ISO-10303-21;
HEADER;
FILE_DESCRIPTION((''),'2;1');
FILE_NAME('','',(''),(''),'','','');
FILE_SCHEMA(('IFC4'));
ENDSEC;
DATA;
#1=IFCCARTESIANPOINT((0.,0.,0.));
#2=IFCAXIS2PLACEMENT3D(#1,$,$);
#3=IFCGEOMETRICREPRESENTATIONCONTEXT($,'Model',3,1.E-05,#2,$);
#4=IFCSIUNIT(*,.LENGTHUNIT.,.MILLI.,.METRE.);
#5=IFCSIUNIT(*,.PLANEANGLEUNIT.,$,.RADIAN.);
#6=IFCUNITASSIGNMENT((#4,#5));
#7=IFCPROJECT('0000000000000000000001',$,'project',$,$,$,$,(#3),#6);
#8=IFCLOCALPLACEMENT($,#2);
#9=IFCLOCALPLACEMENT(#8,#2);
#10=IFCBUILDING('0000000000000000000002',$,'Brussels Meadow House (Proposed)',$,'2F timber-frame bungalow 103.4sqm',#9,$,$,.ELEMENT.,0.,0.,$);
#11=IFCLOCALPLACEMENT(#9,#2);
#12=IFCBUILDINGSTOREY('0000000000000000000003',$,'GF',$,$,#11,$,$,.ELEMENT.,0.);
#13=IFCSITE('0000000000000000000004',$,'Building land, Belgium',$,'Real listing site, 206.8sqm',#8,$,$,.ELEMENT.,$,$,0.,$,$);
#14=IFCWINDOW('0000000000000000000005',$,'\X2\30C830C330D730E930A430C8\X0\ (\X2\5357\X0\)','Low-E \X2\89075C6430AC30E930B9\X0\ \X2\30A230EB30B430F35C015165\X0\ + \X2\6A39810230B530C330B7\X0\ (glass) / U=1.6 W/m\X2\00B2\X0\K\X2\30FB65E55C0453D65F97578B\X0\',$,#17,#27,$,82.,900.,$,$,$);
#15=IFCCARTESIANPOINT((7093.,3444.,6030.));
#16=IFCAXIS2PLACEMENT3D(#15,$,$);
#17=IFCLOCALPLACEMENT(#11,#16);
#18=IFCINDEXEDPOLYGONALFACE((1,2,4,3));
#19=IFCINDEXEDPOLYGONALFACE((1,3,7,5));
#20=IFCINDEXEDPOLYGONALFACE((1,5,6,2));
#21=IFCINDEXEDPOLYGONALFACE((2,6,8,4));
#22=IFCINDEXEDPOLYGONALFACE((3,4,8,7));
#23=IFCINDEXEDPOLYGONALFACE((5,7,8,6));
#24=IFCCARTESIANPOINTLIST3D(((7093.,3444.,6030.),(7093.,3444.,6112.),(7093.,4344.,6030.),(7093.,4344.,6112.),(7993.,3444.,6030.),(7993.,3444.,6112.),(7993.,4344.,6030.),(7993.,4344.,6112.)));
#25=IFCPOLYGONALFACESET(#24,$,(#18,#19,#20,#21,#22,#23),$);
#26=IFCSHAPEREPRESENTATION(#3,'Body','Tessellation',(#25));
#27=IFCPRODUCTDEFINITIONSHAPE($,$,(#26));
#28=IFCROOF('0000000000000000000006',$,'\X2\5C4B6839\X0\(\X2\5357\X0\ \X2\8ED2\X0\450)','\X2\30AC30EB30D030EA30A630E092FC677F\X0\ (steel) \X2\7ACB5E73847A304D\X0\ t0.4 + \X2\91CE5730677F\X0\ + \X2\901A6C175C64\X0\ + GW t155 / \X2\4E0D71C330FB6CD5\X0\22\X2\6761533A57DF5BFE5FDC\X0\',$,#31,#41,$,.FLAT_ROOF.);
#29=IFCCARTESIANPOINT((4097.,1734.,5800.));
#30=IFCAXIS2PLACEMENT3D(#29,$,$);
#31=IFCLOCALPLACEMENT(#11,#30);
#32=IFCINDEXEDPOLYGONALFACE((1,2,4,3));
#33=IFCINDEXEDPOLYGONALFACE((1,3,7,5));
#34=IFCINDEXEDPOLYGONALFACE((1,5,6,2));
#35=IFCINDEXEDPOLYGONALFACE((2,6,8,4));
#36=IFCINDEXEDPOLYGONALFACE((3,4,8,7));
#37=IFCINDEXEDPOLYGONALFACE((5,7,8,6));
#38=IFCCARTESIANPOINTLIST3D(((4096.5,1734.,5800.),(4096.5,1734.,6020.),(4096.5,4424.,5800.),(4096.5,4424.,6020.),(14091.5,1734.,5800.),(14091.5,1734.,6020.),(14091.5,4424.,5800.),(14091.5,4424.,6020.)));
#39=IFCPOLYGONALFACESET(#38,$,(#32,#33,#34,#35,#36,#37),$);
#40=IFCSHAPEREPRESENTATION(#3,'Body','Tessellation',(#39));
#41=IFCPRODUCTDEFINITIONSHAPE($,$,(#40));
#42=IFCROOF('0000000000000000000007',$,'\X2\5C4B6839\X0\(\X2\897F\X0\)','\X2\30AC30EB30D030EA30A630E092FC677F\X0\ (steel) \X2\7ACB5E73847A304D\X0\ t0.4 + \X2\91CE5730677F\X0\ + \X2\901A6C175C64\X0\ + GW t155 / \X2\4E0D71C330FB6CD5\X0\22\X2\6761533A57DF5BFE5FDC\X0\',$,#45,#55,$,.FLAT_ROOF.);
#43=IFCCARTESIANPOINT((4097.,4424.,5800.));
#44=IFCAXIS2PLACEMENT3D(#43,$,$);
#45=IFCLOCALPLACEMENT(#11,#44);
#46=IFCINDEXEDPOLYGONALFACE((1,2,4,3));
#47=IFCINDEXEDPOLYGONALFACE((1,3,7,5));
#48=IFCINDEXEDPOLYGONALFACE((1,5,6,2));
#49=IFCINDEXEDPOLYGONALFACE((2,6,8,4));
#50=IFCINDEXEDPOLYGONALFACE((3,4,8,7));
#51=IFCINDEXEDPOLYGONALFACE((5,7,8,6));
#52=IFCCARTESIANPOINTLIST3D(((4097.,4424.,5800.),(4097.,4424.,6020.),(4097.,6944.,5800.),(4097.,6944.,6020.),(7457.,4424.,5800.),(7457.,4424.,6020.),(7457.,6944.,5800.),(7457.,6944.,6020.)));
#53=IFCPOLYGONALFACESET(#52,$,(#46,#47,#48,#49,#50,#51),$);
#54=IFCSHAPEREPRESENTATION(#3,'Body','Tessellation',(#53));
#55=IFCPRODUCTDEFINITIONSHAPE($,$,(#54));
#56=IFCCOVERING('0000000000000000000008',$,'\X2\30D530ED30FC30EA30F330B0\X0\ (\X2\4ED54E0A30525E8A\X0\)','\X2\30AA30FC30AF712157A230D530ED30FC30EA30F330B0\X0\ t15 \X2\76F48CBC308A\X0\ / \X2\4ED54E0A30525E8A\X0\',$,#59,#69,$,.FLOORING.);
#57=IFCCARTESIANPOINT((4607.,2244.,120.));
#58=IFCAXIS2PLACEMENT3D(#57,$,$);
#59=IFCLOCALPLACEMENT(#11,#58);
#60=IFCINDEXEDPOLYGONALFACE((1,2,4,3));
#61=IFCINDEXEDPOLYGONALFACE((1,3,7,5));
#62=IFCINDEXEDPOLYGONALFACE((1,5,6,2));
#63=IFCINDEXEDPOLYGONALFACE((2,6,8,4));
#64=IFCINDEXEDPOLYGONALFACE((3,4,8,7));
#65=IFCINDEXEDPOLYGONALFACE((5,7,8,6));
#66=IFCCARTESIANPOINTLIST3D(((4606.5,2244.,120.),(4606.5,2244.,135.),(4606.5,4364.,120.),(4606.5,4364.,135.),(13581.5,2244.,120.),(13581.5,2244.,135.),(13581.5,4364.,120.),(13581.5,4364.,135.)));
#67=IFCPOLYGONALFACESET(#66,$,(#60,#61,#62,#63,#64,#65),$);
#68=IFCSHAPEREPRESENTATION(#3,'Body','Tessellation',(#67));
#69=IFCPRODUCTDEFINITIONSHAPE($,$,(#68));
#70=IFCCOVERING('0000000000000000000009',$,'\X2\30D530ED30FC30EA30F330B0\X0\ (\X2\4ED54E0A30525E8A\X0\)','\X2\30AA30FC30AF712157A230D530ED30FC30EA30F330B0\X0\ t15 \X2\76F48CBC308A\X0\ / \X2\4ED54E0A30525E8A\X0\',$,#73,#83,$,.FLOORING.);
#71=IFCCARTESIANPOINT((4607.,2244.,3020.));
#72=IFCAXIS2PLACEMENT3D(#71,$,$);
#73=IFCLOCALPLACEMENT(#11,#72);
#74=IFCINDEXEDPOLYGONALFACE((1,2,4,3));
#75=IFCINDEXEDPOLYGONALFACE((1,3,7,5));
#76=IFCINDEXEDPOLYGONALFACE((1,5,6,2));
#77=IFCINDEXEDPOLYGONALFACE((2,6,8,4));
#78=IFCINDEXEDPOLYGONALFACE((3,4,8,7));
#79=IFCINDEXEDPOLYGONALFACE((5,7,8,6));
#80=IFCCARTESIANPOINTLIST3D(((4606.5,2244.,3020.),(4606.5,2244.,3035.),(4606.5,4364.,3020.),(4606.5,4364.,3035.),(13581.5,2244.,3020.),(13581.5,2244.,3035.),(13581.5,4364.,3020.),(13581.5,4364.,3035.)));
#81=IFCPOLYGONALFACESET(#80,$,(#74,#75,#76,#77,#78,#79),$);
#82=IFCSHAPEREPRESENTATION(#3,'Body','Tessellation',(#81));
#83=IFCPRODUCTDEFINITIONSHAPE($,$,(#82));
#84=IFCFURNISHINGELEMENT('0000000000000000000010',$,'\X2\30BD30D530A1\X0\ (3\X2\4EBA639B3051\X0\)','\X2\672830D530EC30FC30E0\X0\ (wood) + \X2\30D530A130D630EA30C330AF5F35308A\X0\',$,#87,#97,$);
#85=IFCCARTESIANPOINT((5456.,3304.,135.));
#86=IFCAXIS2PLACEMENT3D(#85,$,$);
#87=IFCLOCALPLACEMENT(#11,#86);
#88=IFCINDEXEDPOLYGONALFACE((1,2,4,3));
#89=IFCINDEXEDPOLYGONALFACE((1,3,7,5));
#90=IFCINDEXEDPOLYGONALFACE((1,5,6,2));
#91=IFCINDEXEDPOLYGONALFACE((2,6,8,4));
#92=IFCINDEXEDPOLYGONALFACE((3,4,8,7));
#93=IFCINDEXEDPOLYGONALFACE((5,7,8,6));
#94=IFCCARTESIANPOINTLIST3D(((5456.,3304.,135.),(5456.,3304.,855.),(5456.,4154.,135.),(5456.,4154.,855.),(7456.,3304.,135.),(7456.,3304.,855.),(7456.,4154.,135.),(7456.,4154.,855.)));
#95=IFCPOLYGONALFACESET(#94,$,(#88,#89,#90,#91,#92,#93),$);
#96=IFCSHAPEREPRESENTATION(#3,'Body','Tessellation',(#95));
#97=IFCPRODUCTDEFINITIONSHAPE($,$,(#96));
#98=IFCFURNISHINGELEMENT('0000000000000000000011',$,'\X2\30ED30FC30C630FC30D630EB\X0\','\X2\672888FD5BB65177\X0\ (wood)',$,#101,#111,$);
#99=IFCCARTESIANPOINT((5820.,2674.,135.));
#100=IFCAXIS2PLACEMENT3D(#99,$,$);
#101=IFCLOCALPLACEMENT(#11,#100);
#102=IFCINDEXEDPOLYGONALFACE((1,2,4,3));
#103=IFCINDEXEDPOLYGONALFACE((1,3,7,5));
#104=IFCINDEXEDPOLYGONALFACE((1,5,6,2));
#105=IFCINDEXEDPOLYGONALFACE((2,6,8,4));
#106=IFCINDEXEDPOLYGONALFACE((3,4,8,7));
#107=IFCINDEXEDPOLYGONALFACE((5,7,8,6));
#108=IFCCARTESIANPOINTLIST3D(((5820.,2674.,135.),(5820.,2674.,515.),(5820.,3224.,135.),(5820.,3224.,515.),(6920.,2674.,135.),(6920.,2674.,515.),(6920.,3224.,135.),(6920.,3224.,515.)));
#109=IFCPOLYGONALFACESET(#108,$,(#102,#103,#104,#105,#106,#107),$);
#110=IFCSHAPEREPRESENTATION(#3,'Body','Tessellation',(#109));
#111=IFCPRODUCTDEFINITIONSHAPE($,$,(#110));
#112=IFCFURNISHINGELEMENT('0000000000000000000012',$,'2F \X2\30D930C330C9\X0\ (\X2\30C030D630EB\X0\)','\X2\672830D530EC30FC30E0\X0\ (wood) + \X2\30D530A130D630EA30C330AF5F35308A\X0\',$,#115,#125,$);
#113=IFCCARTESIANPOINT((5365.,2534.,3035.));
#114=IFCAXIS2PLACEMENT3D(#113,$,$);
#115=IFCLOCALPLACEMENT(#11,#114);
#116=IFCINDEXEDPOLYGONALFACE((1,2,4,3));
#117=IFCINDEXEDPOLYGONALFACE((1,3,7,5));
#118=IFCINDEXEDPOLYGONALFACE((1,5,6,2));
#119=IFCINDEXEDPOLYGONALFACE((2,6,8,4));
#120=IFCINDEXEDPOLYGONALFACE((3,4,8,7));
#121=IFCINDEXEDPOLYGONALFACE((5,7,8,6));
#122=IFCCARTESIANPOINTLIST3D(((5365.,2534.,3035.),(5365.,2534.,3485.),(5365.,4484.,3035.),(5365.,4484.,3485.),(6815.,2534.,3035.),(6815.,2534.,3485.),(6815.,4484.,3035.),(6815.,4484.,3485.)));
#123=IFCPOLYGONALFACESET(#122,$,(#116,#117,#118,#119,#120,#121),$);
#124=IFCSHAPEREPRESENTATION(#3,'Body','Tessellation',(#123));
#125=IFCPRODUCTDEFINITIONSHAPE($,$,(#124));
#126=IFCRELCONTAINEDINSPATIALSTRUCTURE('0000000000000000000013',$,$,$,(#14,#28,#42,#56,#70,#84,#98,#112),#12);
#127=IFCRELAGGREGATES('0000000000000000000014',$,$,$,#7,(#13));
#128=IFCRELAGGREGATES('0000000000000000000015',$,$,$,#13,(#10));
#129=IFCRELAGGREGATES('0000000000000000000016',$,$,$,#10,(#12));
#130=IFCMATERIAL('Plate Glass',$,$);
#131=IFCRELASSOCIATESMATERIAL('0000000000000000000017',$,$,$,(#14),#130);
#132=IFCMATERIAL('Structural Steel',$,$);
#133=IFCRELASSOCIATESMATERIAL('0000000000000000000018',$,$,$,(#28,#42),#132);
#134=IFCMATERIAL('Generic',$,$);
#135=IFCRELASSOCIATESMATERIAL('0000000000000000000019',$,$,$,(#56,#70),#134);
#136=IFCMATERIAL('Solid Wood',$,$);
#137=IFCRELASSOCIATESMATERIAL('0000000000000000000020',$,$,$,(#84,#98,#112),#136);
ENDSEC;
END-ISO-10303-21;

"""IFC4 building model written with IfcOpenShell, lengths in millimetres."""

from ifc_helpers import new_model, si_unit, frame, frame_2d, origin, place, context, project, spatial, rectangle, extrude, material, element, save


model = new_model("IFC4")

# Units and contexts
model_context = context("Model", 3, precision=1e-05, world=origin())
ifc_project = project(units=[si_unit("LENGTHUNIT", "METRE", prefix="MILLI"), si_unit("PLANEANGLEUNIT", "RADIAN")], contexts=[model_context])

# Site, building, storey
site_placement = place(None, origin())
site = spatial("IfcSite", under=ifc_project, at=site_placement, Name="Building land, Belgium", ObjectType="Real listing site, 206.8sqm", CompositionType="ELEMENT", RefElevation=0.0)
building_placement = place(site_placement, origin())
building = spatial("IfcBuilding", under=site, at=building_placement, Name="Brussels Meadow House (Proposed)", ObjectType="2F timber-frame bungalow 103.4sqm", CompositionType="ELEMENT", ElevationOfRefHeight=0.0, ElevationOfTerrain=0.0)
storey_placement = place(building_placement, origin())
storey = spatial("IfcBuildingStorey", under=building, at=storey_placement, Name="GF", CompositionType="ELEMENT", Elevation=0.0)

# Shared definitions
ifc_material_1 = material(Name="Solid Wood")

# Shared definitions
ifc_material_2 = material(Name="Plate Glass")

# Window
window_1_placement = place(storey_placement, frame((7093.0, 3444.0, 6030.0)))
element("IfcWindow", 1, at=window_1_placement, inside=storey, material=ifc_material_2, Name="トップライト (南)", Description="Low-E 複層ガラス アルゴン封入 + 樹脂サッシ (glass) / U=1.6 W/m²K・日射取得型", OverallHeight=82.0, OverallWidth=900.0, context=model_context, shape_type="SweptSolid", body=[
    extrude(rectangle(XDim=900.0, YDim=900.0, at=frame_2d((450.0, 450.0))), frame((7093.0, 3444.0, 6030.0)), (0.0, 0.0, 1.0), 82.0),
])

# Roofs
ifc_material_3 = material(Name="Structural Steel")
roof_1_placement = place(storey_placement, frame((4097.0, 1734.0, 5800.0)))
element("IfcRoof", 2, at=roof_1_placement, inside=storey, material=ifc_material_3, Name="屋根(南 軒450)", Description="ガルバリウム鋼板 (steel) 立平葺き t0.4 + 野地板 + 通気層 + GW t155 / 不燃・法22条区域対応", PredefinedType="FLAT_ROOF", context=model_context, shape_type="SweptSolid", body=[
    extrude(rectangle(XDim=9995.0, YDim=2690.0, at=frame_2d((4997.0, 1345.0))), frame((4097.0, 1734.0, 5800.0)), (0.0, 0.0, 1.0), 220.0),
])
roof_2_placement = place(storey_placement, frame((4097.0, 4424.0, 5800.0)))
element("IfcRoof", 3, at=roof_2_placement, inside=storey, material=ifc_material_3, Name="屋根(西)", Description="ガルバリウム鋼板 (steel) 立平葺き t0.4 + 野地板 + 通気層 + GW t155 / 不燃・法22条区域対応", PredefinedType="FLAT_ROOF", context=model_context, shape_type="SweptSolid", body=[
    extrude(rectangle(XDim=3360.0, YDim=2520.0, at=frame_2d((1680.0, 1260.0))), frame((4097.0, 4424.0, 5800.0)), (0.0, 0.0, 1.0), 220.0),
])

# Coverings
ifc_material_4 = material(Name="Generic")
covering_1_placement = place(storey_placement, frame((4607.0, 2244.0, 120.0)))
element("IfcCovering", 4, at=covering_1_placement, inside=storey, material=ifc_material_4, Name="フローリング (仕上げ床)", Description="オーク無垢フローリング t15 直貼り / 仕上げ床", PredefinedType="FLOORING", context=model_context, shape_type="SweptSolid", body=[
    extrude(rectangle(XDim=8975.0, YDim=2120.0, at=frame_2d((4487.0, 1060.0))), frame((4607.0, 2244.0, 120.0)), (0.0, 0.0, 1.0), 15.0),
])
covering_2_placement = place(storey_placement, frame((4607.0, 2244.0, 3020.0)))
element("IfcCovering", 5, at=covering_2_placement, inside=storey, material=ifc_material_4, Name="フローリング (仕上げ床)", Description="オーク無垢フローリング t15 直貼り / 仕上げ床", PredefinedType="FLOORING", context=model_context, shape_type="SweptSolid", body=[
    extrude(rectangle(XDim=8975.0, YDim=2120.0, at=frame_2d((4487.0, 1060.0))), frame((4607.0, 2244.0, 3020.0)), (0.0, 0.0, 1.0), 15.0),
])

# Furnishing elements
furnishing_1_placement = place(storey_placement, frame((5456.0, 3304.0, 135.0)))
element("IfcFurnishingElement", 6, at=furnishing_1_placement, inside=storey, material=ifc_material_1, Name="ソファ (3人掛け)", Description="木フレーム (wood) + ファブリック張り", context=model_context, shape_type="SweptSolid", body=[
    extrude(rectangle(XDim=2000.0, YDim=850.0, at=frame_2d((1000.0, 425.0))), frame((5456.0, 3304.0, 135.0)), (0.0, 0.0, 1.0), 720.0),
])
furnishing_2_placement = place(storey_placement, frame((5820.0, 2674.0, 135.0)))
element("IfcFurnishingElement", 7, at=furnishing_2_placement, inside=storey, material=ifc_material_1, Name="ローテーブル", Description="木製家具 (wood)", context=model_context, shape_type="SweptSolid", body=[
    extrude(rectangle(XDim=1100.0, YDim=550.0, at=frame_2d((550.0, 275.0))), frame((5820.0, 2674.0, 135.0)), (0.0, 0.0, 1.0), 380.0),
])
furnishing_3_placement = place(storey_placement, frame((5365.0, 2534.0, 3035.0)))
element("IfcFurnishingElement", 8, at=furnishing_3_placement, inside=storey, material=ifc_material_1, Name="2F ベッド (ダブル)", Description="木フレーム (wood) + ファブリック張り", context=model_context, shape_type="SweptSolid", body=[
    extrude(rectangle(XDim=1450.0, YDim=1950.0, at=frame_2d((725.0, 975.0))), frame((5365.0, 2534.0, 3035.0)), (0.0, 0.0, 1.0), 450.0),
])

save(model, "model.ifc")
